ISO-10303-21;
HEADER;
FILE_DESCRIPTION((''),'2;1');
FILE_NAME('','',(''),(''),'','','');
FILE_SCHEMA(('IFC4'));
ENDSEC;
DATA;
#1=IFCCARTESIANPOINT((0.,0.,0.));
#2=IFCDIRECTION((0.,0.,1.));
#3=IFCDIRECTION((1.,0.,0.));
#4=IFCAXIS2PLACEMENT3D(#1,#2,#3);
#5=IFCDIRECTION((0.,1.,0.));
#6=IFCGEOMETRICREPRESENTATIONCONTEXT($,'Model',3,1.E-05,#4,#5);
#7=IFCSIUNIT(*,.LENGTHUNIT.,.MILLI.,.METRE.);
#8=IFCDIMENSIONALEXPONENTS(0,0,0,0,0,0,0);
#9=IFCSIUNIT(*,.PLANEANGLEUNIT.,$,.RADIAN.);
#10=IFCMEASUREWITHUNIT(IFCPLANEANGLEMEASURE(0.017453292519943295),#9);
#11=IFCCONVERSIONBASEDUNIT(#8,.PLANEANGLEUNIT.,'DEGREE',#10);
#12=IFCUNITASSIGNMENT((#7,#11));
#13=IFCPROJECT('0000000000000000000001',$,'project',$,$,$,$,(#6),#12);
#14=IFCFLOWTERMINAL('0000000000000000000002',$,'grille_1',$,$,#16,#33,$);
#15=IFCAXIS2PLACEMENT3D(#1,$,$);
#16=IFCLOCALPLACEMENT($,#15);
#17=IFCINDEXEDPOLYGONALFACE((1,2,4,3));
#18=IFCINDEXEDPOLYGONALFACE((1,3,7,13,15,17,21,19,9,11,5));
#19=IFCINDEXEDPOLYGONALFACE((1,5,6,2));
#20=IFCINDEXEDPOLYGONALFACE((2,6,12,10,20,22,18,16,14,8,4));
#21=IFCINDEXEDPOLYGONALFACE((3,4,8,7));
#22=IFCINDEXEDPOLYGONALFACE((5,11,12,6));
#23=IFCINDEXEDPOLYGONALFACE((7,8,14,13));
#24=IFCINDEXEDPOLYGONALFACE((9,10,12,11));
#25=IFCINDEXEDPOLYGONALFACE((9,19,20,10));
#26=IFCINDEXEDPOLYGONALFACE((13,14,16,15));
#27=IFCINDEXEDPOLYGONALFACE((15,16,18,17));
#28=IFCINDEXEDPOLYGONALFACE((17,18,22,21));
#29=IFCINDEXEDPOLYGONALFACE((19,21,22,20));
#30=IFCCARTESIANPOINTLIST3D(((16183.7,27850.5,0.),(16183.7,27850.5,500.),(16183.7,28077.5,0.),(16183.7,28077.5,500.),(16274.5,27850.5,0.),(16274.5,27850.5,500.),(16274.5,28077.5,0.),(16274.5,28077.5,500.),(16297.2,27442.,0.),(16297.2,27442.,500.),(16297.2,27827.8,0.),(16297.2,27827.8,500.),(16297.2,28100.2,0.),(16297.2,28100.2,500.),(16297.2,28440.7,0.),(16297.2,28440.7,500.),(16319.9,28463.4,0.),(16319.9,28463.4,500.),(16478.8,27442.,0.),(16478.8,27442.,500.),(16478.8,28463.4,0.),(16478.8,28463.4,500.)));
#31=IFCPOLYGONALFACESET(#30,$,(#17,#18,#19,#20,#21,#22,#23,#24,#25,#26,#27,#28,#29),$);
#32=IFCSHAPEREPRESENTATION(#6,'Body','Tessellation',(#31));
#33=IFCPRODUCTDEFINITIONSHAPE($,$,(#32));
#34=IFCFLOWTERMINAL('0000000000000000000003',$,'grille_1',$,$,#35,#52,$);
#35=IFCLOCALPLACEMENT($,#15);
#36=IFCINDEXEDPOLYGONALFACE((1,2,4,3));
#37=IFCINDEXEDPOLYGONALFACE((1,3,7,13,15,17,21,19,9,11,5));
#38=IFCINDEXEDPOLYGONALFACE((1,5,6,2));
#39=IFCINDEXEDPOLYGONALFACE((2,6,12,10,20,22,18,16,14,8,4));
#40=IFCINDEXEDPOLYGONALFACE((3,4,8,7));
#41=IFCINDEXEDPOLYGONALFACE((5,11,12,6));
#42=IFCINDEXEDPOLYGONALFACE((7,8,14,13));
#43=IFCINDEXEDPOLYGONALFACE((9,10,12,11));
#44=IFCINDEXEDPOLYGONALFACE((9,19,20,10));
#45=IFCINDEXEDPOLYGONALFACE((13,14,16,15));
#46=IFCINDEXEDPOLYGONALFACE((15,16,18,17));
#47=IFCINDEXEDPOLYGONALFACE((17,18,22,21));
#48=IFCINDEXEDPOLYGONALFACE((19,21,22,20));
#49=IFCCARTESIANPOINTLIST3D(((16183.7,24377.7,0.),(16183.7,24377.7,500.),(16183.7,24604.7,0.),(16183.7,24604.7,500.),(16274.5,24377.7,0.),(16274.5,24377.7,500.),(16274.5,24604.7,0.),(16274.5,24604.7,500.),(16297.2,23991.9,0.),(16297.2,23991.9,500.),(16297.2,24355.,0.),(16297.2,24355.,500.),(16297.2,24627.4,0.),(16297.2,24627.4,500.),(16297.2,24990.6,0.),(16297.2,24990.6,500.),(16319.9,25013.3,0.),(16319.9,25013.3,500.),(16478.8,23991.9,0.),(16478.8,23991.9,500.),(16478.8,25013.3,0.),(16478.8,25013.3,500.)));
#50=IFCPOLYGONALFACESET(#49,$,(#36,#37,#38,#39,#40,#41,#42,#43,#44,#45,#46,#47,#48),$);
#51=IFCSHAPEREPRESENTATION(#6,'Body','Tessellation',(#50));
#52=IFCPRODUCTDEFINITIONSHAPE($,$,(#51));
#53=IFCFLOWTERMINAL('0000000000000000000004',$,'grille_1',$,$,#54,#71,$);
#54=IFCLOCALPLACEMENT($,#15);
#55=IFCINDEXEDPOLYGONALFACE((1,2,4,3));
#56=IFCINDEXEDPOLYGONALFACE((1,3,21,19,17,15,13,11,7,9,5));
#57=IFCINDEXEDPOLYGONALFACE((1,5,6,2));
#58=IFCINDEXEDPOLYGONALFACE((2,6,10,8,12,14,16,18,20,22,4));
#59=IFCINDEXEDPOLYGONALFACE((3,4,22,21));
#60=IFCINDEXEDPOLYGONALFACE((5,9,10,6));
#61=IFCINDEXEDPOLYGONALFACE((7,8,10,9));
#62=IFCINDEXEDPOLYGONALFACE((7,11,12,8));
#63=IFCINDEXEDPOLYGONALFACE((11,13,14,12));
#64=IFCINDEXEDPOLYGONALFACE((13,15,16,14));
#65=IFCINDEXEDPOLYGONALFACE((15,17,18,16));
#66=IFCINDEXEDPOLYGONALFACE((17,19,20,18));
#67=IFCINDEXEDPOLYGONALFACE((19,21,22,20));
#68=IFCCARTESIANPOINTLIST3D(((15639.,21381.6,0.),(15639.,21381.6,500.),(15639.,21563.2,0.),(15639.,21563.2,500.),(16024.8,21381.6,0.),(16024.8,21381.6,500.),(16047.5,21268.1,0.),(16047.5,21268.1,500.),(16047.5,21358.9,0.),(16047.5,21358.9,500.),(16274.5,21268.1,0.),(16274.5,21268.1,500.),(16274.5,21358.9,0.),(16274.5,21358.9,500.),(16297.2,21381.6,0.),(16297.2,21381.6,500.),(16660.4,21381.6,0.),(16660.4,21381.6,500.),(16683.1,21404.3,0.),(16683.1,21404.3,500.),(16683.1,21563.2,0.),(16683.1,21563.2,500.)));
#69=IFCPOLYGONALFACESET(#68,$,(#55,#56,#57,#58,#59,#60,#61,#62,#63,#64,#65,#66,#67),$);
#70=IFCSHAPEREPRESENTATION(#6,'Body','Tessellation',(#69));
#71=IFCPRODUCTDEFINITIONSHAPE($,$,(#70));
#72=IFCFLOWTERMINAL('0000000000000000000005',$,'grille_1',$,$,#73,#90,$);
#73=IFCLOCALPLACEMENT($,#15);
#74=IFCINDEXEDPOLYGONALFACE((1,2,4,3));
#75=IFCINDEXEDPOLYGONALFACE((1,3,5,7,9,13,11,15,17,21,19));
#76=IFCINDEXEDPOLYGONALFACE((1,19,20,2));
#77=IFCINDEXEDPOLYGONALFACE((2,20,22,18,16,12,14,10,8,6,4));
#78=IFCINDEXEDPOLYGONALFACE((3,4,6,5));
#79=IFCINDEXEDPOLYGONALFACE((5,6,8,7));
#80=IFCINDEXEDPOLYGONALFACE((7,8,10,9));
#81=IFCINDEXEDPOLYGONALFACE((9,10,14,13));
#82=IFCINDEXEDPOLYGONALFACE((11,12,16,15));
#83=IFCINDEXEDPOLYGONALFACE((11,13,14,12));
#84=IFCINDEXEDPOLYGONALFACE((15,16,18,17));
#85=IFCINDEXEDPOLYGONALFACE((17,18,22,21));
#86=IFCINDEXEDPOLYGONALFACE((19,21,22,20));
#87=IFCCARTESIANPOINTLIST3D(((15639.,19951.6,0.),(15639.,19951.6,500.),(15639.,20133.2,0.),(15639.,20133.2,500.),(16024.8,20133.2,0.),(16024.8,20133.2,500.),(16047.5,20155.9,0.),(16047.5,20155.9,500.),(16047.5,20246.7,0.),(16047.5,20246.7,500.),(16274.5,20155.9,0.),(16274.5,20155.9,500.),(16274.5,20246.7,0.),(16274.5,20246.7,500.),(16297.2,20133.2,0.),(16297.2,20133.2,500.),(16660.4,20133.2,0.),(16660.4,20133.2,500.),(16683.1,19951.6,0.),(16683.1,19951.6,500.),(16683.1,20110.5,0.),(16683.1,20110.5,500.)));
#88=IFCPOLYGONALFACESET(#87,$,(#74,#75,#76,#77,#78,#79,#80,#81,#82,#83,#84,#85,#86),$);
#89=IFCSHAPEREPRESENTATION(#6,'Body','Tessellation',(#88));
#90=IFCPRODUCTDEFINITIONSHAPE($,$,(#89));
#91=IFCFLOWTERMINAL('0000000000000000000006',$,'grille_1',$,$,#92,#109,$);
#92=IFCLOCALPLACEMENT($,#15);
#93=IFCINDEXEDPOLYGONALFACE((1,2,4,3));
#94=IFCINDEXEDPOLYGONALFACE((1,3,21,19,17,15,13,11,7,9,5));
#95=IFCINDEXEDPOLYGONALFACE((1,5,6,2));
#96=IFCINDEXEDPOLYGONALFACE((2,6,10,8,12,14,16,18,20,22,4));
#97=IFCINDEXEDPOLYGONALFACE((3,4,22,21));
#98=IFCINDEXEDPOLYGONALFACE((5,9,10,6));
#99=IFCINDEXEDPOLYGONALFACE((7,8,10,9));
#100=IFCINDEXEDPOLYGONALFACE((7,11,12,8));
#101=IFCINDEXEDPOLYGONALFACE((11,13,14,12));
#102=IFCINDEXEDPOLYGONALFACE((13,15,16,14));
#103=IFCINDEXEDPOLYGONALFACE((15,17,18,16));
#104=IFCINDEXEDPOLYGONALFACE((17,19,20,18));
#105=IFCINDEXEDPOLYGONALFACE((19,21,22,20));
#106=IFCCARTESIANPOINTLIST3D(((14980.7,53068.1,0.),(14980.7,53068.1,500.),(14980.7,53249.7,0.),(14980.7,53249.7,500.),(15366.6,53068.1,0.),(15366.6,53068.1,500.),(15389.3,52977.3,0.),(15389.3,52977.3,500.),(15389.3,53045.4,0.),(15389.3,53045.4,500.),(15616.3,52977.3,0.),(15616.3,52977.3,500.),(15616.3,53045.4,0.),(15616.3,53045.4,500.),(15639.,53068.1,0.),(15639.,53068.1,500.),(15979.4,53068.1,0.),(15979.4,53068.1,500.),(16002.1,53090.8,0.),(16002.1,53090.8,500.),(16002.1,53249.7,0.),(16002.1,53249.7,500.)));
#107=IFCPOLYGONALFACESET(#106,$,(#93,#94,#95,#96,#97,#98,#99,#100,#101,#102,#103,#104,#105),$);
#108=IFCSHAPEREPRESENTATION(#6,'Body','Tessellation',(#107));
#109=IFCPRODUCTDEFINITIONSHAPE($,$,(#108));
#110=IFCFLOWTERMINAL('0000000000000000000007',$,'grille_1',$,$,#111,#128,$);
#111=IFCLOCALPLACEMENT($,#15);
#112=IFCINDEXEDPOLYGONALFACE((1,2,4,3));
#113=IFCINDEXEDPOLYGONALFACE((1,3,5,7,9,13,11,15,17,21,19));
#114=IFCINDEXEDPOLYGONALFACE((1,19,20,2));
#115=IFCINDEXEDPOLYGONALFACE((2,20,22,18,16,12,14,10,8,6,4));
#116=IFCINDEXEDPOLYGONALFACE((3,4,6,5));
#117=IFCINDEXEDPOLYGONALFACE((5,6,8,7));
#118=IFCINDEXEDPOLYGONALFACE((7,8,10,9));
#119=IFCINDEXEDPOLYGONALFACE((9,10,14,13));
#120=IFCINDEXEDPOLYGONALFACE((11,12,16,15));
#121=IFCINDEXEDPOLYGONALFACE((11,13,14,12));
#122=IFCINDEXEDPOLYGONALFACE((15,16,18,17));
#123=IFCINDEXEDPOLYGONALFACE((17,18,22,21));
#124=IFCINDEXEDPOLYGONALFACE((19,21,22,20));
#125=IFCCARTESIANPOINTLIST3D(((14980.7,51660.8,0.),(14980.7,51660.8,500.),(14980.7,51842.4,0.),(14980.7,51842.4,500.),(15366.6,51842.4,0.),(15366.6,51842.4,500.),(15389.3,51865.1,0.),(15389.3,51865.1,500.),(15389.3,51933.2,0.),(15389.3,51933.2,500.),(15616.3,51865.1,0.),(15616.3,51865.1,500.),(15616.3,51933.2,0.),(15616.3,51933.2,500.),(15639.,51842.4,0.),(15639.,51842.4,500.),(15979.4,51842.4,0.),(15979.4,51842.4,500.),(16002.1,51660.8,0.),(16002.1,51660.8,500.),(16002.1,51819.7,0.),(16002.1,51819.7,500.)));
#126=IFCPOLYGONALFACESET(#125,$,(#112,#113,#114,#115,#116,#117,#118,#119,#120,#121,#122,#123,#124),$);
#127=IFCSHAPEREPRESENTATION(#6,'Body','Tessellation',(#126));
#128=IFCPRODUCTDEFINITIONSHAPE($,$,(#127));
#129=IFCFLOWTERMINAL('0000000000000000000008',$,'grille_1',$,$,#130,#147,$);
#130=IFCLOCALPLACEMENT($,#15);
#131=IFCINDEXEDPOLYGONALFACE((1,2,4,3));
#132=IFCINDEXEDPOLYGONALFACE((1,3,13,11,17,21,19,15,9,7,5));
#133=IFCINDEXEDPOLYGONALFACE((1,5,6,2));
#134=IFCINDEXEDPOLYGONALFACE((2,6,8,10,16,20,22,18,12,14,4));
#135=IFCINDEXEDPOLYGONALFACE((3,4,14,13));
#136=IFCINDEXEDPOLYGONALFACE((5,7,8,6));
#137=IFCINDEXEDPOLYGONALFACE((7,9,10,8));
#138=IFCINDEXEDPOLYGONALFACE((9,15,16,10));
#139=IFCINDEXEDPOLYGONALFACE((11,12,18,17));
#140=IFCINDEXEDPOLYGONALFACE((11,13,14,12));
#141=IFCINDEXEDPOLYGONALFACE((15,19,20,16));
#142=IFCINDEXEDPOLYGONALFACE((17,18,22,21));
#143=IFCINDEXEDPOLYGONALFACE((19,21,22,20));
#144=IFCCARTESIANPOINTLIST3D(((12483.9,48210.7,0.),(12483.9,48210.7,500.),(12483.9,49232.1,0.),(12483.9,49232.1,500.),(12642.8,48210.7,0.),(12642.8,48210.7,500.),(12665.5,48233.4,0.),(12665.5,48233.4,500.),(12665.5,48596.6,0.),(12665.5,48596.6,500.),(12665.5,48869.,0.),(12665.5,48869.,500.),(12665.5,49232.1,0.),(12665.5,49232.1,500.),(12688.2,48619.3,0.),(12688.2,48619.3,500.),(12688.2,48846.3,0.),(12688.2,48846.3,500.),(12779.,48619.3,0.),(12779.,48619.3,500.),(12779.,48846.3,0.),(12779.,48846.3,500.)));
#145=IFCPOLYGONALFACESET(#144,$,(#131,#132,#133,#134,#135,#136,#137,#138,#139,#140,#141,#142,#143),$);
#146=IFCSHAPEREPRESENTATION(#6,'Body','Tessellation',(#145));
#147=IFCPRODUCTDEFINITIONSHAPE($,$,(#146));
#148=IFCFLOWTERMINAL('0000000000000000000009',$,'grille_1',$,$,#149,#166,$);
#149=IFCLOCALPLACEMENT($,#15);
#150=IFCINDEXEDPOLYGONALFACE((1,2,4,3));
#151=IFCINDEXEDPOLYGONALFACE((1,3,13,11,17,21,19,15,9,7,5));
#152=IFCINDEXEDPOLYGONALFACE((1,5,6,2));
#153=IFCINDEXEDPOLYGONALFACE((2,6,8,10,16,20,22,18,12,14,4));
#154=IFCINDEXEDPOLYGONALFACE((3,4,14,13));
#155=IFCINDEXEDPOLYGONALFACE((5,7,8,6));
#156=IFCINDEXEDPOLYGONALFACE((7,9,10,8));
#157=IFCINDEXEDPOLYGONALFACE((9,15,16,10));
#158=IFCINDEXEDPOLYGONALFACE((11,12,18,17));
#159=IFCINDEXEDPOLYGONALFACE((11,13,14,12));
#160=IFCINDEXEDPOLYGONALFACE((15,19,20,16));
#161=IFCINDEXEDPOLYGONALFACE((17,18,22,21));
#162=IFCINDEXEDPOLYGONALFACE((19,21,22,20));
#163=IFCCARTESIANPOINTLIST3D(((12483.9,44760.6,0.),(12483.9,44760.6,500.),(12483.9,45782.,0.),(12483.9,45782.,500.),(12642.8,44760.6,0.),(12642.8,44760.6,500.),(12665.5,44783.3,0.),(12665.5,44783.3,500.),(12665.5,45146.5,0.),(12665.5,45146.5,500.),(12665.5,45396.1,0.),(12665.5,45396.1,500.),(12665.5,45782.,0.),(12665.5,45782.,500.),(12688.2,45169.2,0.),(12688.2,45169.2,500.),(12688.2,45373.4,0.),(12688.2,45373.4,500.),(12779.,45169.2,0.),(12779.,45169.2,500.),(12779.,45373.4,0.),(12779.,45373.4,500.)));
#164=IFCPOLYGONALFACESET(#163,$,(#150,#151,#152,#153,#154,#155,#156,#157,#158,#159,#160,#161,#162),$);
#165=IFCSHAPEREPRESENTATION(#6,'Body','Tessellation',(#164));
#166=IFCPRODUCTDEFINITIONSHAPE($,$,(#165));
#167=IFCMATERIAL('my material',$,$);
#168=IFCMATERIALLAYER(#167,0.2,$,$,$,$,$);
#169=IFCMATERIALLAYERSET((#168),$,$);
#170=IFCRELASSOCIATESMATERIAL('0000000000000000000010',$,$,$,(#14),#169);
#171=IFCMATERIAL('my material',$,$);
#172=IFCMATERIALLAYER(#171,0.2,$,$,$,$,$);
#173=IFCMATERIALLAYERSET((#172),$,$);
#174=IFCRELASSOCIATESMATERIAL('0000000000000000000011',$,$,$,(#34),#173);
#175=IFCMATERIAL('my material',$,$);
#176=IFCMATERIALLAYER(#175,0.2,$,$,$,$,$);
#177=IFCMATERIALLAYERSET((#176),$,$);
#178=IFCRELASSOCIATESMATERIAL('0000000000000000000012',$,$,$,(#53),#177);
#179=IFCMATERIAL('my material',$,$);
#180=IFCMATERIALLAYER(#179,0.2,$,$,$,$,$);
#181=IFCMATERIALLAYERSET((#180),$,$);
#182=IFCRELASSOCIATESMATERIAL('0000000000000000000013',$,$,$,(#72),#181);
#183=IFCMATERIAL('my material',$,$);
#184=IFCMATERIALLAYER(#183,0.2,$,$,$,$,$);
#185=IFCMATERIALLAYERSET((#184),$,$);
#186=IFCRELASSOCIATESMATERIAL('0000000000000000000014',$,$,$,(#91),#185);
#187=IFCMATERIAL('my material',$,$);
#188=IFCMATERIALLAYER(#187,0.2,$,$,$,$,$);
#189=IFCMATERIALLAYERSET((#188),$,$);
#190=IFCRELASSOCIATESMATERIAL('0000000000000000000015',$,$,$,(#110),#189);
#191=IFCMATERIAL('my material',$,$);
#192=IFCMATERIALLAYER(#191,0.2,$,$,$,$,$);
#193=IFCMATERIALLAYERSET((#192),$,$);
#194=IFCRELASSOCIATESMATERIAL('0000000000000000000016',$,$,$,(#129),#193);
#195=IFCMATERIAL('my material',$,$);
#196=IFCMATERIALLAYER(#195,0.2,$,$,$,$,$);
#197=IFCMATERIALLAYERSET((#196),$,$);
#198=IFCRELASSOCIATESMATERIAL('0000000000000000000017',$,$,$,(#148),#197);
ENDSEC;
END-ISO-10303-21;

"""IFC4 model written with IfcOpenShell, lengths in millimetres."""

from ifc_helpers import new_model, entity, si_unit, converted_unit, direction, origin_with_axes, place, context, project, polyline, outline, extrude, material, layer, layer_set, layer_usage, element, save


model = new_model("IFC4")

# Units and contexts
model_context = context("Model", 3, precision=1e-05, world=origin_with_axes(), true_north=direction((0.0, 1.0, 0.0)))
ifc_project = project(units=[si_unit("LENGTHUNIT", "METRE", prefix="MILLI"), converted_unit("PLANEANGLEUNIT", "DEGREE", entity("IfcPlaneAngleMeasure", 0.017453292519943295), si_unit("PLANEANGLEUNIT", "RADIAN"), dimensions=[0, 0, 0, 0, 0, 0, 0])], contexts=[model_context])

# Flow terminals
ifc_material_1 = material(Name="my material")
ifc_layer_1 = layer(ifc_material_1, 0.2)
ifc_layer_set_1 = layer_set([ifc_layer_1])
ifc_layer_usage_1 = layer_usage(ifc_layer_set_1, "AXIS2", "POSITIVE", -0.1)
flow_terminal_1_placement = place(None, origin_with_axes())
element("IfcFlowTerminal", 1, at=flow_terminal_1_placement, material=ifc_layer_usage_1, Name="grille_1", context=model_context, shape_type="SweptSolid", body=[
    extrude(outline(polyline([(16183.7, 27850.5), (16274.5, 27850.5), (16297.2, 27827.8), (16297.2, 27442.0), (16478.8, 27442.0), (16478.8, 28463.4), (16319.9, 28463.4), (16297.2, 28440.7), (16297.2, 28100.2), (16274.5, 28077.5), (16183.7, 28077.5), (16183.7, 27850.5)])), origin_with_axes(), (0.0, 0.0, 1.0), 500.0),
])
ifc_material_2 = material(Name="my material")
ifc_layer_2 = layer(ifc_material_2, 0.2)
ifc_layer_set_2 = layer_set([ifc_layer_2])
ifc_layer_usage_2 = layer_usage(ifc_layer_set_2, "AXIS2", "POSITIVE", -0.1)
flow_terminal_2_placement = place(None, origin_with_axes())
element("IfcFlowTerminal", 2, at=flow_terminal_2_placement, material=ifc_layer_usage_2, Name="grille_1", context=model_context, shape_type="SweptSolid", body=[
    extrude(outline(polyline([(16183.7, 24377.7), (16274.5, 24377.7), (16297.2, 24355.0), (16297.2, 23991.9), (16478.8, 23991.9), (16478.8, 25013.3), (16319.9, 25013.3), (16297.2, 24990.6), (16297.2, 24627.4), (16274.5, 24604.7), (16183.7, 24604.7), (16183.7, 24377.7)])), origin_with_axes(), (0.0, 0.0, 1.0), 500.0),
])
ifc_material_3 = material(Name="my material")
ifc_layer_3 = layer(ifc_material_3, 0.2)
ifc_layer_set_3 = layer_set([ifc_layer_3])
ifc_layer_usage_3 = layer_usage(ifc_layer_set_3, "AXIS2", "POSITIVE", -0.1)
flow_terminal_3_placement = place(None, origin_with_axes())
element("IfcFlowTerminal", 3, at=flow_terminal_3_placement, material=ifc_layer_usage_3, Name="grille_1", context=model_context, shape_type="SweptSolid", body=[
    extrude(outline(polyline([(15639.0, 21381.6), (16024.8, 21381.6), (16047.5, 21358.9), (16047.5, 21268.1), (16274.5, 21268.1), (16274.5, 21358.9), (16297.2, 21381.6), (16660.4, 21381.6), (16683.1, 21404.3), (16683.1, 21563.2), (15639.0, 21563.2), (15639.0, 21381.6)])), origin_with_axes(), (0.0, 0.0, 1.0), 500.0),
])
ifc_material_4 = material(Name="my material")
ifc_layer_4 = layer(ifc_material_4, 0.2)
ifc_layer_set_4 = layer_set([ifc_layer_4])
ifc_layer_usage_4 = layer_usage(ifc_layer_set_4, "AXIS2", "POSITIVE", -0.1)
flow_terminal_4_placement = place(None, origin_with_axes())
element("IfcFlowTerminal", 4, at=flow_terminal_4_placement, material=ifc_layer_usage_4, Name="grille_1", context=model_context, shape_type="SweptSolid", body=[
    extrude(outline(polyline([(15639.0, 19951.6), (16683.1, 19951.6), (16683.1, 20110.5), (16660.4, 20133.2), (16297.2, 20133.2), (16274.5, 20155.9), (16274.5, 20246.7), (16047.5, 20246.7), (16047.5, 20155.9), (16024.8, 20133.2), (15639.0, 20133.2), (15639.0, 19951.6)])), origin_with_axes(), (0.0, 0.0, 1.0), 500.0),
])
ifc_material_5 = material(Name="my material")
ifc_layer_5 = layer(ifc_material_5, 0.2)
ifc_layer_set_5 = layer_set([ifc_layer_5])
ifc_layer_usage_5 = layer_usage(ifc_layer_set_5, "AXIS2", "POSITIVE", -0.1)
flow_terminal_5_placement = place(None, origin_with_axes())
element("IfcFlowTerminal", 5, at=flow_terminal_5_placement, material=ifc_layer_usage_5, Name="grille_1", context=model_context, shape_type="SweptSolid", body=[
    extrude(outline(polyline([(14980.7, 53068.1), (15366.6, 53068.1), (15389.3, 53045.4), (15389.3, 52977.3), (15616.3, 52977.3), (15616.3, 53045.4), (15639.0, 53068.1), (15979.4, 53068.1), (16002.1, 53090.8), (16002.1, 53249.7), (14980.7, 53249.7), (14980.7, 53068.1)])), origin_with_axes(), (0.0, 0.0, 1.0), 500.0),
])
ifc_material_6 = material(Name="my material")
ifc_layer_6 = layer(ifc_material_6, 0.2)
ifc_layer_set_6 = layer_set([ifc_layer_6])
ifc_layer_usage_6 = layer_usage(ifc_layer_set_6, "AXIS2", "POSITIVE", -0.1)
flow_terminal_6_placement = place(None, origin_with_axes())
element("IfcFlowTerminal", 6, at=flow_terminal_6_placement, material=ifc_layer_usage_6, Name="grille_1", context=model_context, shape_type="SweptSolid", body=[
    extrude(outline(polyline([(14980.7, 51660.8), (16002.1, 51660.8), (16002.1, 51819.7), (15979.4, 51842.4), (15639.0, 51842.4), (15616.3, 51865.1), (15616.3, 51933.2), (15389.3, 51933.2), (15389.3, 51865.1), (15366.6, 51842.4), (14980.7, 51842.4), (14980.7, 51660.8)])), origin_with_axes(), (0.0, 0.0, 1.0), 500.0),
])
ifc_material_7 = material(Name="my material")
ifc_layer_7 = layer(ifc_material_7, 0.2)
ifc_layer_set_7 = layer_set([ifc_layer_7])
ifc_layer_usage_7 = layer_usage(ifc_layer_set_7, "AXIS2", "POSITIVE", -0.1)
flow_terminal_7_placement = place(None, origin_with_axes())
element("IfcFlowTerminal", 7, at=flow_terminal_7_placement, material=ifc_layer_usage_7, Name="grille_1", context=model_context, shape_type="SweptSolid", body=[
    extrude(outline(polyline([(12483.9, 48210.7), (12642.8, 48210.7), (12665.5, 48233.4), (12665.5, 48596.6), (12688.2, 48619.3), (12779.0, 48619.3), (12779.0, 48846.3), (12688.2, 48846.3), (12665.5, 48869.0), (12665.5, 49232.1), (12483.9, 49232.1), (12483.9, 48210.7)])), origin_with_axes(), (0.0, 0.0, 1.0), 500.0),
])
ifc_material_8 = material(Name="my material")
ifc_layer_8 = layer(ifc_material_8, 0.2)
ifc_layer_set_8 = layer_set([ifc_layer_8])
ifc_layer_usage_8 = layer_usage(ifc_layer_set_8, "AXIS2", "POSITIVE", -0.1)
flow_terminal_8_placement = place(None, origin_with_axes())
element("IfcFlowTerminal", 8, at=flow_terminal_8_placement, material=ifc_layer_usage_8, Name="grille_1", context=model_context, shape_type="SweptSolid", body=[
    extrude(outline(polyline([(12483.9, 44760.6), (12642.8, 44760.6), (12665.5, 44783.3), (12665.5, 45146.5), (12688.2, 45169.2), (12779.0, 45169.2), (12779.0, 45373.4), (12688.2, 45373.4), (12665.5, 45396.1), (12665.5, 45782.0), (12483.9, 45782.0), (12483.9, 44760.6)])), origin_with_axes(), (0.0, 0.0, 1.0), 500.0),
])

save(model, "model.ifc")
